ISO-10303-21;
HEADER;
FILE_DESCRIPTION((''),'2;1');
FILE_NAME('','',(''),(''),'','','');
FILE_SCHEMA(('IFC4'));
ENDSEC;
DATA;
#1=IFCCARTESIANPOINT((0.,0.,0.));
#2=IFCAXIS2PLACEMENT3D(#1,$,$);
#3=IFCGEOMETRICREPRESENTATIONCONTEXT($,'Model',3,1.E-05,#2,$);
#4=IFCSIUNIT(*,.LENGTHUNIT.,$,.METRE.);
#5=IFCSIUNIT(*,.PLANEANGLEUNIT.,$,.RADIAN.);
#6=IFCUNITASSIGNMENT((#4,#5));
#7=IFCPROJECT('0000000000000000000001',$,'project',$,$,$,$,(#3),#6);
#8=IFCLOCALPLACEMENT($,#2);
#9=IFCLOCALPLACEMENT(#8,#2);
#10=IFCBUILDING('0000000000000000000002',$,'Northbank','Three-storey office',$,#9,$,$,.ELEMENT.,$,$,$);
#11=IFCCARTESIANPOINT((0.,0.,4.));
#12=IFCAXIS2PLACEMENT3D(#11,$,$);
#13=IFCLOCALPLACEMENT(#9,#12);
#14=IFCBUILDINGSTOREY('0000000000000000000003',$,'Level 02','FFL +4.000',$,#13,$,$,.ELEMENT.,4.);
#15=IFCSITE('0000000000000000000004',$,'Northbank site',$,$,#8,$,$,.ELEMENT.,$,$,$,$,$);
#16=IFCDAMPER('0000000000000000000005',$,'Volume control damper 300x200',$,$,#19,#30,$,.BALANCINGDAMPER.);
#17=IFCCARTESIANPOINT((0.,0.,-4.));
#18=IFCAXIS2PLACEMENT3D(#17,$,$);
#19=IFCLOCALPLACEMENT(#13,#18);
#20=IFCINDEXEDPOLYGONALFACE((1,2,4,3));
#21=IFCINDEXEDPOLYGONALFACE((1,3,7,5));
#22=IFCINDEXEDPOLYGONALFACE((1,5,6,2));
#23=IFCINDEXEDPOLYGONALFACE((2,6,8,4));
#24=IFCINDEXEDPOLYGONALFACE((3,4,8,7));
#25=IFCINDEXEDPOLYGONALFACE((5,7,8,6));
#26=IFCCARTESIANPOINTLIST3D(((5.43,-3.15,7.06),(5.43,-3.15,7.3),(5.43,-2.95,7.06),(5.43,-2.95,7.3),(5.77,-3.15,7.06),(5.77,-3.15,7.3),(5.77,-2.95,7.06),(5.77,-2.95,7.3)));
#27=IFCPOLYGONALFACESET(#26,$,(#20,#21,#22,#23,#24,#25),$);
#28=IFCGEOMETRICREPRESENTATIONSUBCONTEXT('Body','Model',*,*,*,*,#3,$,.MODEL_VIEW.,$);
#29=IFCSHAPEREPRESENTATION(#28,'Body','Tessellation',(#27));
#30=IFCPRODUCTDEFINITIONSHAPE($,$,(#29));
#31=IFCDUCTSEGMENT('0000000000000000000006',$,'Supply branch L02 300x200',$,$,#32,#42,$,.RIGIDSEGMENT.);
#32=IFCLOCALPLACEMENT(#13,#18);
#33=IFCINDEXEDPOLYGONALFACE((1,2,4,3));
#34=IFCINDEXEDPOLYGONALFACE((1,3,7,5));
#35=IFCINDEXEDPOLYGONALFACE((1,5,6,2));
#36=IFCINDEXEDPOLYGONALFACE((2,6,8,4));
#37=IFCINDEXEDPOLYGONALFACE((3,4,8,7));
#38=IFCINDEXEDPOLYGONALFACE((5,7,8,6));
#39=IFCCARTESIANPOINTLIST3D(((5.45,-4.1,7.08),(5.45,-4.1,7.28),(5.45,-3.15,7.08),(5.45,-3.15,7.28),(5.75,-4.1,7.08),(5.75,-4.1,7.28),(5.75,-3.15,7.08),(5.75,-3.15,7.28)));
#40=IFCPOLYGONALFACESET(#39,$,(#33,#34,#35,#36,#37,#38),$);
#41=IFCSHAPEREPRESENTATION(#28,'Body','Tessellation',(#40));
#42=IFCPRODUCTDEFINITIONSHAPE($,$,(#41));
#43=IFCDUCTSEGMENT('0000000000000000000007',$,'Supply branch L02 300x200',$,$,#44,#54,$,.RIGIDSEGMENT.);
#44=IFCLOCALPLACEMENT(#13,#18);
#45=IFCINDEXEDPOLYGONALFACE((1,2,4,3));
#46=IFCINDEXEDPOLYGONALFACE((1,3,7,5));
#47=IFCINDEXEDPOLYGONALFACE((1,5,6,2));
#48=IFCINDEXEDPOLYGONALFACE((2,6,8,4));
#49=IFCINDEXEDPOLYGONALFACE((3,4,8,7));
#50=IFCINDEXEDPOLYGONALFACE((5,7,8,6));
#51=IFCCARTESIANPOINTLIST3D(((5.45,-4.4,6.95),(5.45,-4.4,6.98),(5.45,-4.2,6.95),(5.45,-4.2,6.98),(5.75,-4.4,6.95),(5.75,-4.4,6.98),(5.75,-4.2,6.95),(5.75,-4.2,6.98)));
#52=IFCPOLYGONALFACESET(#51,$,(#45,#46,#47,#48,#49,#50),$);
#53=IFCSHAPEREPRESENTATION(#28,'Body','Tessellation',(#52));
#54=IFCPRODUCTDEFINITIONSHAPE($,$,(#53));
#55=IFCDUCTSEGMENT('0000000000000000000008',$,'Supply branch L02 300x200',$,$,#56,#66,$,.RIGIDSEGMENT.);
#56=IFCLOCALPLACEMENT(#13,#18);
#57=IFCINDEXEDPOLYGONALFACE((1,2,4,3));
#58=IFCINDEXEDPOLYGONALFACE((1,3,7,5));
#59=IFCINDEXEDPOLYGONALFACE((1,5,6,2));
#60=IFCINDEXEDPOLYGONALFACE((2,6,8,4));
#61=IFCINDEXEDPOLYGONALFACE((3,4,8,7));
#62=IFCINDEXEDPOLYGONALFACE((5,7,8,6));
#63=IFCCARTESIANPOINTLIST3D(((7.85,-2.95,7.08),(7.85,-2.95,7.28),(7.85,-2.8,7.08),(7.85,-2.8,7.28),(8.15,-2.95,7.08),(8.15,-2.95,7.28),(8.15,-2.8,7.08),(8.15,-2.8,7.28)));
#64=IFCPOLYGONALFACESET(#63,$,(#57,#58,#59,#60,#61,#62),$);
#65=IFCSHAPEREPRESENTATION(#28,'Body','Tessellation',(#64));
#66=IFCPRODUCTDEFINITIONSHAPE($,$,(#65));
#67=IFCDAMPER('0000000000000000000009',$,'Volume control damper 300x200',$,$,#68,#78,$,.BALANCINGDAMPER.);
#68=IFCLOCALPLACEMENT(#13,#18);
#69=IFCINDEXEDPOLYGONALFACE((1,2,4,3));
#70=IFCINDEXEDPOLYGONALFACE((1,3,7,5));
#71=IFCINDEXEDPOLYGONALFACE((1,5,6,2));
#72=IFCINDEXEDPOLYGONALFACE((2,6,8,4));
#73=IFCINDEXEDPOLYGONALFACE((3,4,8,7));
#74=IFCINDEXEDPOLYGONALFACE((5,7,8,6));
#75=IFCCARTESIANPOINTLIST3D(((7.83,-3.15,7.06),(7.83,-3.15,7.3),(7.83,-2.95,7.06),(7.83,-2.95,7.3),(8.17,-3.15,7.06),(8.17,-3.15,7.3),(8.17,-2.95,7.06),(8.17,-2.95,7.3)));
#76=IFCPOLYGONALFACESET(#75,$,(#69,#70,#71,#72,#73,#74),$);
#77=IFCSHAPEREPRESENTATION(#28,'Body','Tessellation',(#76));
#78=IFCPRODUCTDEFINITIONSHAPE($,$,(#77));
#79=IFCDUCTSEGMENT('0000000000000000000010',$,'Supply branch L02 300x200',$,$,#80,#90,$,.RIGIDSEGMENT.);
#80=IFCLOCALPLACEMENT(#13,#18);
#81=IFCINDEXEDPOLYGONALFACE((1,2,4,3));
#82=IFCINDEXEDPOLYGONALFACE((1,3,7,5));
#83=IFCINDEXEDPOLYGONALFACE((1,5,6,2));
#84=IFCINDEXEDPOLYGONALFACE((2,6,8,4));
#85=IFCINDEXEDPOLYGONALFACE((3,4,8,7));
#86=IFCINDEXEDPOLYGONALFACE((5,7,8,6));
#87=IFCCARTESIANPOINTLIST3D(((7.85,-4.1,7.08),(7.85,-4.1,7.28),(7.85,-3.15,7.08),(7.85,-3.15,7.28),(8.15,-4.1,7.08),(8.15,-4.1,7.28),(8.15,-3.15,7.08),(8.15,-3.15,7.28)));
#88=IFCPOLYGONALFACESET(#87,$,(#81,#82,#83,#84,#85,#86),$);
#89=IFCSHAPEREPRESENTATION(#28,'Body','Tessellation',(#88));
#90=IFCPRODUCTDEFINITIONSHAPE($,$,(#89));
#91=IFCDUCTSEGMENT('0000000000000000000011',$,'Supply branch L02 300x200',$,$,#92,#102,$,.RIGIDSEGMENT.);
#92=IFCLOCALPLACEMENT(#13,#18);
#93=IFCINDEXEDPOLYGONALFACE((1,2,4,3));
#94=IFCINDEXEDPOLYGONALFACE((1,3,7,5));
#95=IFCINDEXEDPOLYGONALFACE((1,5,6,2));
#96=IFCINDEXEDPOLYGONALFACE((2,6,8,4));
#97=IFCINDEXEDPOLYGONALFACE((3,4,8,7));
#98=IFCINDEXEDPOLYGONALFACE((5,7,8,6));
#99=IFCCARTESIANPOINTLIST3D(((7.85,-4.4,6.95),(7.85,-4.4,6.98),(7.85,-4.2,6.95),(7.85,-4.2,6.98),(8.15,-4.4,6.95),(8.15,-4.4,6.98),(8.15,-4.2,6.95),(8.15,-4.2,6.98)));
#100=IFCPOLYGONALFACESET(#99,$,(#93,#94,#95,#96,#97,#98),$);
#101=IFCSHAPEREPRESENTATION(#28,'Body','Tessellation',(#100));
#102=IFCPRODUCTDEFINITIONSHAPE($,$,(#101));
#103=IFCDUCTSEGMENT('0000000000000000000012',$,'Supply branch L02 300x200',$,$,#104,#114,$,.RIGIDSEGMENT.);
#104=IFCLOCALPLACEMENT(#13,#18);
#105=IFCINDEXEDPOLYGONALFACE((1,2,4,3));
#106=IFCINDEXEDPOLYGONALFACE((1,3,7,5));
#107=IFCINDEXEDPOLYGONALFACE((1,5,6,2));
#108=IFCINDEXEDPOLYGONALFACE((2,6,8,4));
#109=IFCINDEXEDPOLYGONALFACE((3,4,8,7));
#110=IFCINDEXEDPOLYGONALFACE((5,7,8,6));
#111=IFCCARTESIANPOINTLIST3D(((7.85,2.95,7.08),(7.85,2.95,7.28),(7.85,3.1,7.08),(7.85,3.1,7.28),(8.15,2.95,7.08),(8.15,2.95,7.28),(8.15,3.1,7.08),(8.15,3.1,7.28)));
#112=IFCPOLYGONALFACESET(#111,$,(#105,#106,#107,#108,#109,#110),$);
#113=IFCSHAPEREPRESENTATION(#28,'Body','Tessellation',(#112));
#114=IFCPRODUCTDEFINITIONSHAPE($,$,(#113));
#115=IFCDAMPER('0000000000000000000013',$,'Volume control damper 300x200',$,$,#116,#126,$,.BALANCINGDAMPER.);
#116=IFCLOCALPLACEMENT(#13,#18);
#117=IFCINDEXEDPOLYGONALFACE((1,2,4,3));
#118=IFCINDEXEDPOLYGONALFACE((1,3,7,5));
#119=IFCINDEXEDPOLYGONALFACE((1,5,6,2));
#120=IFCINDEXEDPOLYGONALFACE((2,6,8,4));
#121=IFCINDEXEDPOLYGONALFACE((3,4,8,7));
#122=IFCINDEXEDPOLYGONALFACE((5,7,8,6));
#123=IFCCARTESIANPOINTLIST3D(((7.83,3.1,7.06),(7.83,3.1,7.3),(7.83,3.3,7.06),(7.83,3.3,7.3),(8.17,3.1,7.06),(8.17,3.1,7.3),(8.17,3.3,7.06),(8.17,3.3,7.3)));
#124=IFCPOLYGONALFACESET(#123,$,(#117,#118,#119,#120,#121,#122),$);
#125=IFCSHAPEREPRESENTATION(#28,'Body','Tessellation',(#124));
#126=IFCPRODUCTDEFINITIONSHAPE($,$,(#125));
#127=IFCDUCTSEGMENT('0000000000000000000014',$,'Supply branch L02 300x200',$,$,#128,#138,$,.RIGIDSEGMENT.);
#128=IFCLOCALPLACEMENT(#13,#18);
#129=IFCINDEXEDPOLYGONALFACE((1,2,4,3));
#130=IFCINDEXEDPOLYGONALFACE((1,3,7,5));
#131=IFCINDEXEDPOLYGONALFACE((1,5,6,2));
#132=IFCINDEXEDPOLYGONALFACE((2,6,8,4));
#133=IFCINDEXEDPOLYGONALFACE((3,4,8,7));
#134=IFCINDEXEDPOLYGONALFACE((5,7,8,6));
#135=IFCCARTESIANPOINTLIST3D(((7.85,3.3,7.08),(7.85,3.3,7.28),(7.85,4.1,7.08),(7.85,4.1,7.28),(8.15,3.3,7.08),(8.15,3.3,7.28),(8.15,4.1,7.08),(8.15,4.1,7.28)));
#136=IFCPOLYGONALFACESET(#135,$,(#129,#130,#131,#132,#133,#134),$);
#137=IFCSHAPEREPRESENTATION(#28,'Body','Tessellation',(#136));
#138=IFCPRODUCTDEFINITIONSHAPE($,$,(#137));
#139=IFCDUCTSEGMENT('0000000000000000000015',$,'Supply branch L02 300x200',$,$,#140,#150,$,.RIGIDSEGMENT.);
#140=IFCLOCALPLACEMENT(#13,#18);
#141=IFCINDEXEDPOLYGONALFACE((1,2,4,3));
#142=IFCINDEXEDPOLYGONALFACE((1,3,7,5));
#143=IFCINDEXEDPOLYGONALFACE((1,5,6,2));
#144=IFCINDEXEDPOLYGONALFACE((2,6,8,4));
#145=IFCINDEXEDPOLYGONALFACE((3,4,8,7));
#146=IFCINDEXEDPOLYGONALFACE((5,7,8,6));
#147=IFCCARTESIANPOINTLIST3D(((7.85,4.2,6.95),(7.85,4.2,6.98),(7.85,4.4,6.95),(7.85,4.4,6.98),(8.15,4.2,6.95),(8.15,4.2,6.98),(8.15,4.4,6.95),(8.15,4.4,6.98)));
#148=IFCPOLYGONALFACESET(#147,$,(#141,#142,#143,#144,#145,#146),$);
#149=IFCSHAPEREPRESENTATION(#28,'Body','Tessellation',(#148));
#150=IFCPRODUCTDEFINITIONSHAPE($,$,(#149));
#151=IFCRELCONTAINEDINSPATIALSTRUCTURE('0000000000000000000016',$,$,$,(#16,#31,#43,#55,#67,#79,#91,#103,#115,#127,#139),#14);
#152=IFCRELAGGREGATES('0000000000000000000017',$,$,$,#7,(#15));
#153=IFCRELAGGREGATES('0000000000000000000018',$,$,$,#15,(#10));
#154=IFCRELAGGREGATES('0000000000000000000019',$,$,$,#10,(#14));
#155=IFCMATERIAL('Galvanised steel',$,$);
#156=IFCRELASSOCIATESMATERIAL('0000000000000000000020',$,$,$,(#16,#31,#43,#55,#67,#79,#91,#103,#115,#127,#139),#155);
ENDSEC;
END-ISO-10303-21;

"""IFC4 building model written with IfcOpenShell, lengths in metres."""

from ifc_helpers import new_model, si_unit, frame, origin, place, context, subcontext, project, spatial, rectangle, extrude, material, element, save


model = new_model("IFC4")

# Units and contexts
model_context = context("Model", 3, precision=1e-05, world=origin())
body_context = subcontext(model_context, "Body", "Model", "MODEL_VIEW")
ifc_project = project(units=[si_unit("LENGTHUNIT", "METRE"), si_unit("PLANEANGLEUNIT", "RADIAN")], contexts=[model_context])

# Site, building, storey
site_placement = place(None, origin())
site = spatial("IfcSite", under=ifc_project, at=site_placement, Name="Northbank site", CompositionType="ELEMENT")
building_placement = place(site_placement, origin())
building = spatial("IfcBuilding", under=site, at=building_placement, Name="Northbank", Description="Three-storey office", CompositionType="ELEMENT")
storey_placement = place(building_placement, frame((0.0, 0.0, 4.0)))
storey = spatial("IfcBuildingStorey", under=building, at=storey_placement, Name="Level 02", Description="FFL +4.000", CompositionType="ELEMENT", Elevation=4.0)

# Shared definitions
ifc_material_1 = material(Name="Galvanised steel")

# Damper
damper_1_placement = place(storey_placement, frame((0.0, 0.0, -4.0)))
element("IfcDamper", 1, at=damper_1_placement, inside=storey, material=ifc_material_1, Name="Volume control damper 300x200", PredefinedType="BALANCINGDAMPER", context=body_context, shape_type="SweptSolid", body=[
    extrude(rectangle(XDim=0.34, YDim=0.24), frame((5.6, -2.95, 7.18), z_axis=(0.0, -1.0, 0.0), x_axis=(1.0, 0.0, 0.0)), (0.0, 0.0, 1.0), 0.2),
])

# Duct segments
duct_segment_1_placement = place(storey_placement, frame((0.0, 0.0, -4.0)))
element("IfcDuctSegment", 2, at=duct_segment_1_placement, inside=storey, material=ifc_material_1, Name="Supply branch L02 300x200", PredefinedType="RIGIDSEGMENT", context=body_context, shape_type="SweptSolid", body=[
    extrude(rectangle(XDim=0.3, YDim=0.2), frame((5.6, -3.15, 7.18), z_axis=(0.0, -1.0, 0.0), x_axis=(1.0, 0.0, 0.0)), (0.0, 0.0, 1.0), 0.95),
])
duct_segment_2_placement = place(storey_placement, frame((0.0, 0.0, -4.0)))
element("IfcDuctSegment", 3, at=duct_segment_2_placement, inside=storey, material=ifc_material_1, Name="Supply branch L02 300x200", PredefinedType="RIGIDSEGMENT", context=body_context, shape_type="SweptSolid", body=[
    extrude(rectangle(XDim=0.3, YDim=0.2), frame((5.6, -4.3, 6.98), z_axis=(0.0, 0.0, -1.0), x_axis=(1.0, 0.0, 0.0)), (0.0, 0.0, 1.0), 0.03),
])

# Duct segment
duct_segment_3_placement = place(storey_placement, frame((0.0, 0.0, -4.0)))
element("IfcDuctSegment", 4, at=duct_segment_3_placement, inside=storey, material=ifc_material_1, Name="Supply branch L02 300x200", PredefinedType="RIGIDSEGMENT", context=body_context, shape_type="SweptSolid", body=[
    extrude(rectangle(XDim=0.3, YDim=0.2), frame((8.0, -2.8, 7.18), z_axis=(0.0, -1.0, 0.0), x_axis=(1.0, 0.0, 0.0)), (0.0, 0.0, 1.0), 0.15),
])

# Damper
damper_2_placement = place(storey_placement, frame((0.0, 0.0, -4.0)))
element("IfcDamper", 5, at=damper_2_placement, inside=storey, material=ifc_material_1, Name="Volume control damper 300x200", PredefinedType="BALANCINGDAMPER", context=body_context, shape_type="SweptSolid", body=[
    extrude(rectangle(XDim=0.34, YDim=0.24), frame((8.0, -2.95, 7.18), z_axis=(0.0, -1.0, 0.0), x_axis=(1.0, 0.0, 0.0)), (0.0, 0.0, 1.0), 0.2),
])

# Duct segments
duct_segment_4_placement = place(storey_placement, frame((0.0, 0.0, -4.0)))
element("IfcDuctSegment", 6, at=duct_segment_4_placement, inside=storey, material=ifc_material_1, Name="Supply branch L02 300x200", PredefinedType="RIGIDSEGMENT", context=body_context, shape_type="SweptSolid", body=[
    extrude(rectangle(XDim=0.3, YDim=0.2), frame((8.0, -3.15, 7.18), z_axis=(0.0, -1.0, 0.0), x_axis=(1.0, 0.0, 0.0)), (0.0, 0.0, 1.0), 0.95),
])
duct_segment_5_placement = place(storey_placement, frame((0.0, 0.0, -4.0)))
element("IfcDuctSegment", 7, at=duct_segment_5_placement, inside=storey, material=ifc_material_1, Name="Supply branch L02 300x200", PredefinedType="RIGIDSEGMENT", context=body_context, shape_type="SweptSolid", body=[
    extrude(rectangle(XDim=0.3, YDim=0.2), frame((8.0, -4.3, 6.98), z_axis=(0.0, 0.0, -1.0), x_axis=(1.0, 0.0, 0.0)), (0.0, 0.0, 1.0), 0.03),
])

# Duct segment
duct_segment_6_placement = place(storey_placement, frame((0.0, 0.0, -4.0)))
element("IfcDuctSegment", 8, at=duct_segment_6_placement, inside=storey, material=ifc_material_1, Name="Supply branch L02 300x200", PredefinedType="RIGIDSEGMENT", context=body_context, shape_type="SweptSolid", body=[
    extrude(rectangle(XDim=0.3, YDim=0.2), frame((8.0, 2.95, 7.18), z_axis=(0.0, 1.0, 0.0), x_axis=(-1.0, 0.0, 0.0)), (0.0, 0.0, 1.0), 0.15),
])

# Damper
damper_3_placement = place(storey_placement, frame((0.0, 0.0, -4.0)))
element("IfcDamper", 9, at=damper_3_placement, inside=storey, material=ifc_material_1, Name="Volume control damper 300x200", PredefinedType="BALANCINGDAMPER", context=body_context, shape_type="SweptSolid", body=[
    extrude(rectangle(XDim=0.34, YDim=0.24), frame((8.0, 3.1, 7.18), z_axis=(0.0, 1.0, 0.0), x_axis=(-1.0, 0.0, 0.0)), (0.0, 0.0, 1.0), 0.2),
])

# Duct segments
duct_segment_7_placement = place(storey_placement, frame((0.0, 0.0, -4.0)))
element("IfcDuctSegment", 10, at=duct_segment_7_placement, inside=storey, material=ifc_material_1, Name="Supply branch L02 300x200", PredefinedType="RIGIDSEGMENT", context=body_context, shape_type="SweptSolid", body=[
    extrude(rectangle(XDim=0.3, YDim=0.2), frame((8.0, 3.3, 7.18), z_axis=(0.0, 1.0, 0.0), x_axis=(-1.0, 0.0, 0.0)), (0.0, 0.0, 1.0), 0.8),
])
duct_segment_8_placement = place(storey_placement, frame((0.0, 0.0, -4.0)))
element("IfcDuctSegment", 11, at=duct_segment_8_placement, inside=storey, material=ifc_material_1, Name="Supply branch L02 300x200", PredefinedType="RIGIDSEGMENT", context=body_context, shape_type="SweptSolid", body=[
    extrude(rectangle(XDim=0.3, YDim=0.2), frame((8.0, 4.3, 6.98), z_axis=(0.0, 0.0, -1.0), x_axis=(-1.0, 0.0, 0.0)), (0.0, 0.0, 1.0), 0.03),
])

save(model, "model.ifc")
